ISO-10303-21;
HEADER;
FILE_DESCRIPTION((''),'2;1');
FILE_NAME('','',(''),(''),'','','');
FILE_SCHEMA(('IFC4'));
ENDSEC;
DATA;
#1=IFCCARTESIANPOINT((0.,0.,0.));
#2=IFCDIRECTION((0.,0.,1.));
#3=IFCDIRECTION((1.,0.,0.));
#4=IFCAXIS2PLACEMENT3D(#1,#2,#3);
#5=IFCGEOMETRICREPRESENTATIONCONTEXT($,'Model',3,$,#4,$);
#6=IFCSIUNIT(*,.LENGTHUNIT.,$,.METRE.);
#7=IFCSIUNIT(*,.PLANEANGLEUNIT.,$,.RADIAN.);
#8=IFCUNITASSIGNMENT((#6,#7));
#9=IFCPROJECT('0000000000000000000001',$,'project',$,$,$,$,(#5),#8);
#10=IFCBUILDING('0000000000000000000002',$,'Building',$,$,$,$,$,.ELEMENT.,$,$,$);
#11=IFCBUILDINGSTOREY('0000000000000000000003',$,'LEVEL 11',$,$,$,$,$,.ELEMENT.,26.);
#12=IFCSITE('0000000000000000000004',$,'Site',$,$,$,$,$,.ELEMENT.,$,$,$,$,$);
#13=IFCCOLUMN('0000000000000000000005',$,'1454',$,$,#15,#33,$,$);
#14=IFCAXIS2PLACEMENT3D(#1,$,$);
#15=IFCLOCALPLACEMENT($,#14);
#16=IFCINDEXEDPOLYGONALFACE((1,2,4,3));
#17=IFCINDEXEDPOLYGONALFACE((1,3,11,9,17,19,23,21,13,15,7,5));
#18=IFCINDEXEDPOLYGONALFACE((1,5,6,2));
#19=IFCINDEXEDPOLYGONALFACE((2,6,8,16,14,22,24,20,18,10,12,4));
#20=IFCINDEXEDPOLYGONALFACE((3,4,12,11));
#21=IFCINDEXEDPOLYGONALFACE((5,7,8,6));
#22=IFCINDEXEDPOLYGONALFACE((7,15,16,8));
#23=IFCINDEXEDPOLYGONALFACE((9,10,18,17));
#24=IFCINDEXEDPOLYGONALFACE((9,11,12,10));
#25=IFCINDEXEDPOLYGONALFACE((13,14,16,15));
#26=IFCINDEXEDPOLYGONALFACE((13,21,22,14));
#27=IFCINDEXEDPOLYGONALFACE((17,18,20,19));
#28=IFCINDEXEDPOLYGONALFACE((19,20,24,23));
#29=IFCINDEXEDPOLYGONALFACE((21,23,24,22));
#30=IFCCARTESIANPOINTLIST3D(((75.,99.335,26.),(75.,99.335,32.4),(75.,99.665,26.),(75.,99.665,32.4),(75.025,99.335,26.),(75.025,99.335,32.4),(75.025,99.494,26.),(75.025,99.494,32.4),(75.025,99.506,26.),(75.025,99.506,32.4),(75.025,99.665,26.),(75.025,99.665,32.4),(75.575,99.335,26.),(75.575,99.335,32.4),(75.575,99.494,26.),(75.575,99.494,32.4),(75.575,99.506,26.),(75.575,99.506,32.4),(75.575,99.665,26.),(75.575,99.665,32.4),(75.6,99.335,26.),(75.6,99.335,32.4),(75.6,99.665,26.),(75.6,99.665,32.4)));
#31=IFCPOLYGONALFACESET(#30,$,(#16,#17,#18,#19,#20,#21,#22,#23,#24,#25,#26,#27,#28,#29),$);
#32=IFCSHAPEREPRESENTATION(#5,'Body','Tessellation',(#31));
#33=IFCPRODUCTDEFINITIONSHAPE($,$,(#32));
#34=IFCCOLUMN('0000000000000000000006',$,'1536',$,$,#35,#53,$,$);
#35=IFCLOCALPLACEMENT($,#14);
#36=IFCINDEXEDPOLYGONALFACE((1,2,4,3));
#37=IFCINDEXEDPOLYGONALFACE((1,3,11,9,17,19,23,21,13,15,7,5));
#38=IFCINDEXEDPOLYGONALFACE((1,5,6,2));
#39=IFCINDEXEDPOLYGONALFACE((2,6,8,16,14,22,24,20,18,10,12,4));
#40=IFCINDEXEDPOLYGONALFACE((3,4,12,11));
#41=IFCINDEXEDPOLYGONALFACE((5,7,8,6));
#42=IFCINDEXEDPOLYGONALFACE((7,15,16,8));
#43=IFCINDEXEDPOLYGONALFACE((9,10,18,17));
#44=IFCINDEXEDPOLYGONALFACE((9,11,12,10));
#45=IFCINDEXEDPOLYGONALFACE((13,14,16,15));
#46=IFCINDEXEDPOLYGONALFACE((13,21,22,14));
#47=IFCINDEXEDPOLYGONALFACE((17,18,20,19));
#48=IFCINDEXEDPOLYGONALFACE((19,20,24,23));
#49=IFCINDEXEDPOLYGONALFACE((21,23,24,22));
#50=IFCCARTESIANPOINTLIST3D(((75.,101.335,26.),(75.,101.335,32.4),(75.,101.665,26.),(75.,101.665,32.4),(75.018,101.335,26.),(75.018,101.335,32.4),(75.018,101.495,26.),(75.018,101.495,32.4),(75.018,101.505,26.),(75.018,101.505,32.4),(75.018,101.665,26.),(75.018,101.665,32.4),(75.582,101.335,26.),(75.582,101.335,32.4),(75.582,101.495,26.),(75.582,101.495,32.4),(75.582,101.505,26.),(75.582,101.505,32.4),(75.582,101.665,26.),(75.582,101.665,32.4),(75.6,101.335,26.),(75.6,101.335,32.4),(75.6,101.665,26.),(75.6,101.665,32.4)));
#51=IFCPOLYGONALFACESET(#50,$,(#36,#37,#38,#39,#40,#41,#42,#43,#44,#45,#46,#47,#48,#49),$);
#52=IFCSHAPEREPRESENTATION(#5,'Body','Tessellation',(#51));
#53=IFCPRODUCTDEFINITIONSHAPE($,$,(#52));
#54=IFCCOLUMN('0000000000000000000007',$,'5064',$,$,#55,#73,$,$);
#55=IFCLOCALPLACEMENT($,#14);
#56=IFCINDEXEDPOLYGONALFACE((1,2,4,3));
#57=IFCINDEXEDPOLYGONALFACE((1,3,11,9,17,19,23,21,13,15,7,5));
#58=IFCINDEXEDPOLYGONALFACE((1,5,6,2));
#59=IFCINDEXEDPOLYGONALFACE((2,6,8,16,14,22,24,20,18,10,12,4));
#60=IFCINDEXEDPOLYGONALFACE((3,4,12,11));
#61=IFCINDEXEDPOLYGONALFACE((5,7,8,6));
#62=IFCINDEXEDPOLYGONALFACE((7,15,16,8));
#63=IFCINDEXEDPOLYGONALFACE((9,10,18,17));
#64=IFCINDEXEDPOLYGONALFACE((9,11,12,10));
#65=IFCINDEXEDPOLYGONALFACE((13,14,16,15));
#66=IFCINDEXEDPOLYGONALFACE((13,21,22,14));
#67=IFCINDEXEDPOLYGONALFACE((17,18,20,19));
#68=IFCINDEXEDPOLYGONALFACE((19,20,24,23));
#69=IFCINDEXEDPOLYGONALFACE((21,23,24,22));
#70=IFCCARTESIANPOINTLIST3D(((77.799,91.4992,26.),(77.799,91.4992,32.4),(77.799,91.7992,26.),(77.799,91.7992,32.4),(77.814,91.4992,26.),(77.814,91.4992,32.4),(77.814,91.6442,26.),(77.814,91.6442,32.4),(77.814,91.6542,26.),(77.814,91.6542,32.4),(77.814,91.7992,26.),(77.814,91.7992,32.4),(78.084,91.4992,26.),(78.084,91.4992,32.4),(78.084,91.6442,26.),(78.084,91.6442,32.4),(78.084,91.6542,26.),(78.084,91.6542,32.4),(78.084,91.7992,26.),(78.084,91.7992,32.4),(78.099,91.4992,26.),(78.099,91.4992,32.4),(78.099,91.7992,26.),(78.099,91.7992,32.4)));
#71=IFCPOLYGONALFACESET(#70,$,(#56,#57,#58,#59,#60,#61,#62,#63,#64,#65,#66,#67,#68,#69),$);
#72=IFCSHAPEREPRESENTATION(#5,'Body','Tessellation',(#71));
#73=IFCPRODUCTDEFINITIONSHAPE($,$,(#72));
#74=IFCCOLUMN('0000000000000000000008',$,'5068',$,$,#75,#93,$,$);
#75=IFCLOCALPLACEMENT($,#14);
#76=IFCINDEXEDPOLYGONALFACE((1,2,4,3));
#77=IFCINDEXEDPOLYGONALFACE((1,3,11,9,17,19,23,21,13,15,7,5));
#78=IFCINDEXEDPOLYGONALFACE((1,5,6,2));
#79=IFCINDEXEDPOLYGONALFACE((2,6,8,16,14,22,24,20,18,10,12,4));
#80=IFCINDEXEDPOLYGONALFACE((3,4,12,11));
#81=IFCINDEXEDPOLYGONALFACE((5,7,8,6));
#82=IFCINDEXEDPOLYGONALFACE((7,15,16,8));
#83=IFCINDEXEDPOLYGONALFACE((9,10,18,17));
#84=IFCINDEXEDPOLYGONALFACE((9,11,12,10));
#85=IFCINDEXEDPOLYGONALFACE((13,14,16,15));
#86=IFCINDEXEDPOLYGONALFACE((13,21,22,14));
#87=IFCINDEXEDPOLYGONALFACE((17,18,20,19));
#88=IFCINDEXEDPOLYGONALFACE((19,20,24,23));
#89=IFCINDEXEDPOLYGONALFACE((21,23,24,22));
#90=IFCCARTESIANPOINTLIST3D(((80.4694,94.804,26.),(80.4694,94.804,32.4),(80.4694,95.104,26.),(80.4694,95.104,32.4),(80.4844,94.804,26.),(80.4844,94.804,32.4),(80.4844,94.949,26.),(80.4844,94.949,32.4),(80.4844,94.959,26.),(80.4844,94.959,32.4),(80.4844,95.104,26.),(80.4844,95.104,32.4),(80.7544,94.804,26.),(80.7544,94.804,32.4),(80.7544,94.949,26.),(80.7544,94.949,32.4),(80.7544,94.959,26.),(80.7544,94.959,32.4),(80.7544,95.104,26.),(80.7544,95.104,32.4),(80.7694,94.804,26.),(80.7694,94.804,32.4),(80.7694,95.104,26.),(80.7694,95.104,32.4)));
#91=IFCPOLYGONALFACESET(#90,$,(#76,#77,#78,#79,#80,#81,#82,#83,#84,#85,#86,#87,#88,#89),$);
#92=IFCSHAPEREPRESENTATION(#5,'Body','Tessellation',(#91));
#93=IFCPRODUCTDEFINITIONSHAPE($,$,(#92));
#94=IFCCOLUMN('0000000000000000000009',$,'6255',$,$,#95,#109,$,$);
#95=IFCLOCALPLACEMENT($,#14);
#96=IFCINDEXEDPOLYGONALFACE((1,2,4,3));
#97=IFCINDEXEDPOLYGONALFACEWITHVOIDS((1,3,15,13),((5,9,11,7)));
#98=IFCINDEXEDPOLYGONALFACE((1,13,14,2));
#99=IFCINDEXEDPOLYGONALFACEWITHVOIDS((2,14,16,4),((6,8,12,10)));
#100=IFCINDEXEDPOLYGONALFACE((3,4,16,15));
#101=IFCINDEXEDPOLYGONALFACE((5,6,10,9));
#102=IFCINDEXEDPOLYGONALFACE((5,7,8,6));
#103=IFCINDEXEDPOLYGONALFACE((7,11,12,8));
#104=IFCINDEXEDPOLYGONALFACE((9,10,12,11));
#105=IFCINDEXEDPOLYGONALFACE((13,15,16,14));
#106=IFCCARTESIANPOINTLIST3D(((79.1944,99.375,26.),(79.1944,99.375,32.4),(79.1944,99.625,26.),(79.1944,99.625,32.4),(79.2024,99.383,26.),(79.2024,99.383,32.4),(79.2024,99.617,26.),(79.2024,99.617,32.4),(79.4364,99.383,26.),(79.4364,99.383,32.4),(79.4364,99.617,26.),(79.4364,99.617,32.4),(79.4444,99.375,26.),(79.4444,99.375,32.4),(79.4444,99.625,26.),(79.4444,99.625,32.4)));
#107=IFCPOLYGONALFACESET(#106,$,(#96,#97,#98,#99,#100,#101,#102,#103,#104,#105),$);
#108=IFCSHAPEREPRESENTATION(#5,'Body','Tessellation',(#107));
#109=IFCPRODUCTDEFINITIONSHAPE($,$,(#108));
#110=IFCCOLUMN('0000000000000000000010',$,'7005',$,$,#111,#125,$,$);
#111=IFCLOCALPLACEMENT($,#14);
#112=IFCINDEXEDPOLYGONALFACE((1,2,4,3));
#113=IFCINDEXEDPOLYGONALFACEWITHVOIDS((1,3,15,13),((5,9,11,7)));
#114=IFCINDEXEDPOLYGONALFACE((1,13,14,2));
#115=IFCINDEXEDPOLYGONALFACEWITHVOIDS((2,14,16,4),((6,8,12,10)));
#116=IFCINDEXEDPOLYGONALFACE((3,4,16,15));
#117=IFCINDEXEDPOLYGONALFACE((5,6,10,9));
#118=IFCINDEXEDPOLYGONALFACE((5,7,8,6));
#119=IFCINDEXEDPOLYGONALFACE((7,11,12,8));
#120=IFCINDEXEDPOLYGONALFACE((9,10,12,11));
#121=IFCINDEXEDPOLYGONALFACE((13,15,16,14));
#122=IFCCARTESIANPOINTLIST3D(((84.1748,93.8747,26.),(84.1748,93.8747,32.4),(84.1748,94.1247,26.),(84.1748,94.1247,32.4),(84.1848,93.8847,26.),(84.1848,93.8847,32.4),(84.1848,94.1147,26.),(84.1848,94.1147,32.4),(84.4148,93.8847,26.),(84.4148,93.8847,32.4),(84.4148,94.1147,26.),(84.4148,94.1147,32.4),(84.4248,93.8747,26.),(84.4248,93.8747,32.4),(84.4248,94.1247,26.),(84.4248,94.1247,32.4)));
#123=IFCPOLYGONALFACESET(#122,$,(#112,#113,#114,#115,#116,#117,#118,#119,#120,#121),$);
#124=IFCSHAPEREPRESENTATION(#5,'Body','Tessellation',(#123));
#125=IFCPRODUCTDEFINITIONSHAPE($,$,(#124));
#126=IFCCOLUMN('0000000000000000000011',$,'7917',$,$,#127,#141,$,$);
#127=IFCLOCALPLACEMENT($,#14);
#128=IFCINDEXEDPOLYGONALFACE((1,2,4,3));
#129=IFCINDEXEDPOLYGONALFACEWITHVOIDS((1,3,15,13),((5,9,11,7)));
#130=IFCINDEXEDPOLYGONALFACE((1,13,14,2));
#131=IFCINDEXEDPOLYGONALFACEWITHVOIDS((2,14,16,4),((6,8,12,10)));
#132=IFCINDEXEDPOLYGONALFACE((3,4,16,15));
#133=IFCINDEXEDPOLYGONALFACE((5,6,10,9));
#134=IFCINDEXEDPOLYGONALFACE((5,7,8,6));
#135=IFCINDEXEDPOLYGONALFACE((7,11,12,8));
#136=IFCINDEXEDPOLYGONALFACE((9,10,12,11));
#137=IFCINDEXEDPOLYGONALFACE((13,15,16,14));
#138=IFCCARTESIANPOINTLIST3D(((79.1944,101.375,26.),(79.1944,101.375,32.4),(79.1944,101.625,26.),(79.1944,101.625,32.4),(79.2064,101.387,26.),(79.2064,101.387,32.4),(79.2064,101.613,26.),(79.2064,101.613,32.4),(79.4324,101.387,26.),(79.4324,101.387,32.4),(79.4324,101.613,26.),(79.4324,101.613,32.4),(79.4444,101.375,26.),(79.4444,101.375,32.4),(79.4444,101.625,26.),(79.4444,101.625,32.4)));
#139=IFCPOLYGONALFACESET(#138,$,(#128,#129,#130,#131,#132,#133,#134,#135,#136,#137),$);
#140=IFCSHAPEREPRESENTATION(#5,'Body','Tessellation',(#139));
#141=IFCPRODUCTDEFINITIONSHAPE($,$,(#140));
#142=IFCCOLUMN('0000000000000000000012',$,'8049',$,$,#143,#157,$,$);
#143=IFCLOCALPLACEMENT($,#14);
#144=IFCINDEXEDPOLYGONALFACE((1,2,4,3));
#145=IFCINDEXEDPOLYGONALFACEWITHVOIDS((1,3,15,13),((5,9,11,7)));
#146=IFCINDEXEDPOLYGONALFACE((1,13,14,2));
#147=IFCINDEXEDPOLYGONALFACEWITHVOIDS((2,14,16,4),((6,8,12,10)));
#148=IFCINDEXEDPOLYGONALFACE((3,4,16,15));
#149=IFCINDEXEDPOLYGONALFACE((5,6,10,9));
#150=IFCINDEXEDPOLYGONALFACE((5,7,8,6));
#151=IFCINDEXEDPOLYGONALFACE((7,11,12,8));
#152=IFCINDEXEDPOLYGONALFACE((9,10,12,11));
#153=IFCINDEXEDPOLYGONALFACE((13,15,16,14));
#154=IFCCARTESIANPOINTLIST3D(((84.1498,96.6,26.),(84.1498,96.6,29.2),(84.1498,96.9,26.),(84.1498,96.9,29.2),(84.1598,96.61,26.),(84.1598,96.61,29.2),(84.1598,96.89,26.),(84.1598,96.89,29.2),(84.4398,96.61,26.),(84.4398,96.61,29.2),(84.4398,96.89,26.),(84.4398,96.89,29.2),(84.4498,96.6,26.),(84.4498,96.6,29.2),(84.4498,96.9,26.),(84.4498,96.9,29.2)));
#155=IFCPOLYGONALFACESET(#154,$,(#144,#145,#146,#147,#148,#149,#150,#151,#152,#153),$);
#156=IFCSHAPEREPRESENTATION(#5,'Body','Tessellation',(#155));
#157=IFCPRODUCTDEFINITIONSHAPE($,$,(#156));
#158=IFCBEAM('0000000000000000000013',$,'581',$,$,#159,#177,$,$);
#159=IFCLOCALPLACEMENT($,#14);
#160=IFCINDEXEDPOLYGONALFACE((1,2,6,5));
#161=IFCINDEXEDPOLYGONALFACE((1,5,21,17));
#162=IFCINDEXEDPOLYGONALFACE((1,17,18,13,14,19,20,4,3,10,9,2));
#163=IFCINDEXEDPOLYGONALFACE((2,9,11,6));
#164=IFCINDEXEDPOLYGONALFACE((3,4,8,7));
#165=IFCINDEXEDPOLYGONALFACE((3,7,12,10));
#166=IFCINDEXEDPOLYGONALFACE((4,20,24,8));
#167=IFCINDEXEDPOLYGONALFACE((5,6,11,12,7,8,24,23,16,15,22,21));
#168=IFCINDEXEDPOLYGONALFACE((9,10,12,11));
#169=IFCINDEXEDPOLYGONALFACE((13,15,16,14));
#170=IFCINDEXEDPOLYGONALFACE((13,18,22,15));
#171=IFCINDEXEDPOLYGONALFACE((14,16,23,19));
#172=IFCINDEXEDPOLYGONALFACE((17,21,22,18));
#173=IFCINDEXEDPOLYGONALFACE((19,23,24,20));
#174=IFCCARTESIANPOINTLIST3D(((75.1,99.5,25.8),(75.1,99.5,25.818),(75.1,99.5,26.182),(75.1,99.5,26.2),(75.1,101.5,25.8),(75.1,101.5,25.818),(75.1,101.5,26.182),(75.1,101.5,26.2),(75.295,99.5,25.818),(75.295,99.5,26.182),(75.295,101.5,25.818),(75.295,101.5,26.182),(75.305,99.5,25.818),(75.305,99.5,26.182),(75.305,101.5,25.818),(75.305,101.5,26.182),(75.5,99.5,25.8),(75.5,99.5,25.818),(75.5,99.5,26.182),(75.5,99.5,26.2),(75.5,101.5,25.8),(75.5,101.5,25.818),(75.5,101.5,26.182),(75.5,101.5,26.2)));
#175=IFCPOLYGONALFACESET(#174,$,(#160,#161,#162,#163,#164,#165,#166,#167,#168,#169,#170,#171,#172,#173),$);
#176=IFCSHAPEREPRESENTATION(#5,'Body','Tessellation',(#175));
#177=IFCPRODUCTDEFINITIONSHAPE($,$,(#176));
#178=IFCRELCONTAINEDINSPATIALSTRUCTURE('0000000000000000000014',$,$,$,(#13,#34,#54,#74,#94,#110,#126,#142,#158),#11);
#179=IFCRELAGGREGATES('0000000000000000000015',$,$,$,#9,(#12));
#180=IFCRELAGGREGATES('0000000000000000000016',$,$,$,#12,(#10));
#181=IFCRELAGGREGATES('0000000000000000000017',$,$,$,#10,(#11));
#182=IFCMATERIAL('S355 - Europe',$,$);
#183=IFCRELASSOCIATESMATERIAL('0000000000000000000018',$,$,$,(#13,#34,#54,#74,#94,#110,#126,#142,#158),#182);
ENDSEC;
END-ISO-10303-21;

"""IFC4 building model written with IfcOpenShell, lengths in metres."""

from ifc_helpers import new_model, si_unit, frame, origin_with_axes, origin_2d_with_axis, place, context, project, spatial, hollow_rectangle, i_section, extrude, material, material_profile, profile_set, profile_usage, element, save


model = new_model("IFC4")

# Units and contexts
model_context = context("Model", 3, world=origin_with_axes())
ifc_project = project(units=[si_unit("LENGTHUNIT", "METRE"), si_unit("PLANEANGLEUNIT", "RADIAN")], contexts=[model_context])

# Site, building, storey
site = spatial("IfcSite", under=ifc_project, Name="Site", CompositionType="ELEMENT")
building = spatial("IfcBuilding", under=site, Name="Building", CompositionType="ELEMENT")
storey = spatial("IfcBuildingStorey", under=building, Name="LEVEL 11", CompositionType="ELEMENT", Elevation=26.0)

# Columns
ifc_material = material(Name="S355 - Europe")
ifc_material_profile_1 = material_profile(ifc_material, i_section(OverallWidth=0.33, OverallDepth=0.6, WebThickness=0.012, FlangeThickness=0.025, at=origin_2d_with_axis()))
ifc_profile_set_1 = profile_set([ifc_material_profile_1])
ifc_profile_usage_1 = profile_usage(ifc_profile_set_1, cardinal=10)
column_1_placement = place(None, frame((75.3, 99.5, 26.0), z_axis=(0.0, 0.0, 1.0), x_axis=(0.0, -1.0, 0.0)))
element("IfcColumn", 1, at=column_1_placement, inside=storey, material=ifc_profile_usage_1, Name="1454", context=model_context, shape_type="SweptSolid", body=[
    extrude(i_section(OverallWidth=0.33, OverallDepth=0.6, WebThickness=0.012, FlangeThickness=0.025, at=origin_2d_with_axis()), origin_with_axes(), (0.0, 0.0, 1.0), 6.4),
])
ifc_material_profile_2 = material_profile(ifc_material, i_section(OverallWidth=0.33, OverallDepth=0.6, WebThickness=0.01, FlangeThickness=0.018, at=origin_2d_with_axis()))
ifc_profile_set_2 = profile_set([ifc_material_profile_2])
ifc_profile_usage_2 = profile_usage(ifc_profile_set_2, cardinal=10)
column_2_placement = place(None, frame((75.3, 101.5, 26.0), z_axis=(0.0, 0.0, 1.0), x_axis=(0.0, -1.0, 0.0)))
element("IfcColumn", 2, at=column_2_placement, inside=storey, material=ifc_profile_usage_2, Name="1536", context=model_context, shape_type="SweptSolid", body=[
    extrude(i_section(OverallWidth=0.33, OverallDepth=0.6, WebThickness=0.01, FlangeThickness=0.018, at=origin_2d_with_axis()), origin_with_axes(), (0.0, 0.0, 1.0), 6.4),
])
ifc_material_profile_3 = material_profile(ifc_material, i_section(OverallWidth=0.3, OverallDepth=0.3, WebThickness=0.01, FlangeThickness=0.015, at=origin_2d_with_axis()))
ifc_profile_set_3 = profile_set([ifc_material_profile_3])
ifc_profile_usage_3 = profile_usage(ifc_profile_set_3, cardinal=10)
column_3_placement = place(None, frame((77.949, 91.6492, 26.0), z_axis=(0.0, 0.0, 1.0), x_axis=(0.0, -1.0, 0.0)))
element("IfcColumn", 3, at=column_3_placement, inside=storey, material=ifc_profile_usage_3, Name="5064", context=model_context, shape_type="SweptSolid", body=[
    extrude(i_section(OverallWidth=0.3, OverallDepth=0.3, WebThickness=0.01, FlangeThickness=0.015, at=origin_2d_with_axis()), origin_with_axes(), (0.0, 0.0, 1.0), 6.4),
])
ifc_material_profile_4 = material_profile(ifc_material, i_section(OverallWidth=0.3, OverallDepth=0.3, WebThickness=0.01, FlangeThickness=0.015, at=origin_2d_with_axis()))
ifc_profile_set_4 = profile_set([ifc_material_profile_4])
ifc_profile_usage_4 = profile_usage(ifc_profile_set_4, cardinal=10)
column_4_placement = place(None, frame((80.6194, 94.954, 26.0), z_axis=(0.0, 0.0, 1.0), x_axis=(0.0, -1.0, 0.0)))
element("IfcColumn", 4, at=column_4_placement, inside=storey, material=ifc_profile_usage_4, Name="5068", context=model_context, shape_type="SweptSolid", body=[
    extrude(i_section(OverallWidth=0.3, OverallDepth=0.3, WebThickness=0.01, FlangeThickness=0.015, at=origin_2d_with_axis()), origin_with_axes(), (0.0, 0.0, 1.0), 6.4),
])
ifc_material_profile_5 = material_profile(ifc_material, hollow_rectangle(XDim=0.25, YDim=0.25, WallThickness=0.008, at=origin_2d_with_axis()))
ifc_profile_set_5 = profile_set([ifc_material_profile_5])
ifc_profile_usage_5 = profile_usage(ifc_profile_set_5, cardinal=10)
column_5_placement = place(None, frame((79.3194, 99.5, 26.0), z_axis=(0.0, 0.0, 1.0), x_axis=(0.0, -1.0, 0.0)))
element("IfcColumn", 5, at=column_5_placement, inside=storey, material=ifc_profile_usage_5, Name="6255", context=model_context, shape_type="SweptSolid", body=[
    extrude(hollow_rectangle(XDim=0.25, YDim=0.25, WallThickness=0.008, at=origin_2d_with_axis()), origin_with_axes(), (0.0, 0.0, 1.0), 6.4),
])
ifc_material_profile_6 = material_profile(ifc_material, hollow_rectangle(XDim=0.25, YDim=0.25, WallThickness=0.01, at=origin_2d_with_axis()))
ifc_profile_set_6 = profile_set([ifc_material_profile_6])
ifc_profile_usage_6 = profile_usage(ifc_profile_set_6, cardinal=10)
column_6_placement = place(None, frame((84.2998, 93.9997, 26.0), z_axis=(0.0, 0.0, 1.0), x_axis=(0.0, -1.0, 0.0)))
element("IfcColumn", 6, at=column_6_placement, inside=storey, material=ifc_profile_usage_6, Name="7005", context=model_context, shape_type="SweptSolid", body=[
    extrude(hollow_rectangle(XDim=0.25, YDim=0.25, WallThickness=0.01, at=origin_2d_with_axis()), origin_with_axes(), (0.0, 0.0, 1.0), 6.4),
])
ifc_material_profile_7 = material_profile(ifc_material, hollow_rectangle(XDim=0.25, YDim=0.25, WallThickness=0.012, at=origin_2d_with_axis()))
ifc_profile_set_7 = profile_set([ifc_material_profile_7])
ifc_profile_usage_7 = profile_usage(ifc_profile_set_7, cardinal=10)
column_7_placement = place(None, frame((79.3194, 101.5, 26.0), z_axis=(0.0, 0.0, 1.0), x_axis=(0.0, -1.0, 0.0)))
element("IfcColumn", 7, at=column_7_placement, inside=storey, material=ifc_profile_usage_7, Name="7917", context=model_context, shape_type="SweptSolid", body=[
    extrude(hollow_rectangle(XDim=0.25, YDim=0.25, WallThickness=0.012, at=origin_2d_with_axis()), origin_with_axes(), (0.0, 0.0, 1.0), 6.4),
])
ifc_material_profile_8 = material_profile(ifc_material, hollow_rectangle(XDim=0.3, YDim=0.3, WallThickness=0.01, at=origin_2d_with_axis()))
ifc_profile_set_8 = profile_set([ifc_material_profile_8])
ifc_profile_usage_8 = profile_usage(ifc_profile_set_8, cardinal=10)
column_8_placement = place(None, frame((84.2998, 96.75, 26.0), z_axis=(0.0, 0.0, 1.0), x_axis=(0.0, -1.0, 0.0)))
element("IfcColumn", 8, at=column_8_placement, inside=storey, material=ifc_profile_usage_8, Name="8049", context=model_context, shape_type="SweptSolid", body=[
    extrude(hollow_rectangle(XDim=0.3, YDim=0.3, WallThickness=0.01, at=origin_2d_with_axis()), origin_with_axes(), (0.0, 0.0, 1.0), 3.2),
])

# Beam
ifc_material_profile_9 = material_profile(ifc_material, i_section(OverallWidth=0.4, OverallDepth=0.4, WebThickness=0.01, FlangeThickness=0.018, at=origin_2d_with_axis()))
ifc_profile_set_9 = profile_set([ifc_material_profile_9])
ifc_profile_usage_9 = profile_usage(ifc_profile_set_9, cardinal=10)
beam_1_placement = place(None, frame((75.3, 101.5, 26.0), z_axis=(0.0, -1.0, 0.0), x_axis=(1.0, 0.0, 0.0)))
element("IfcBeam", 9, at=beam_1_placement, inside=storey, material=ifc_profile_usage_9, Name="581", context=model_context, shape_type="SweptSolid", body=[
    extrude(i_section(OverallWidth=0.4, OverallDepth=0.4, WebThickness=0.01, FlangeThickness=0.018, at=origin_2d_with_axis()), origin_with_axes(), (0.0, 0.0, 1.0), 2.0),
])

save(model, "model.ifc")
